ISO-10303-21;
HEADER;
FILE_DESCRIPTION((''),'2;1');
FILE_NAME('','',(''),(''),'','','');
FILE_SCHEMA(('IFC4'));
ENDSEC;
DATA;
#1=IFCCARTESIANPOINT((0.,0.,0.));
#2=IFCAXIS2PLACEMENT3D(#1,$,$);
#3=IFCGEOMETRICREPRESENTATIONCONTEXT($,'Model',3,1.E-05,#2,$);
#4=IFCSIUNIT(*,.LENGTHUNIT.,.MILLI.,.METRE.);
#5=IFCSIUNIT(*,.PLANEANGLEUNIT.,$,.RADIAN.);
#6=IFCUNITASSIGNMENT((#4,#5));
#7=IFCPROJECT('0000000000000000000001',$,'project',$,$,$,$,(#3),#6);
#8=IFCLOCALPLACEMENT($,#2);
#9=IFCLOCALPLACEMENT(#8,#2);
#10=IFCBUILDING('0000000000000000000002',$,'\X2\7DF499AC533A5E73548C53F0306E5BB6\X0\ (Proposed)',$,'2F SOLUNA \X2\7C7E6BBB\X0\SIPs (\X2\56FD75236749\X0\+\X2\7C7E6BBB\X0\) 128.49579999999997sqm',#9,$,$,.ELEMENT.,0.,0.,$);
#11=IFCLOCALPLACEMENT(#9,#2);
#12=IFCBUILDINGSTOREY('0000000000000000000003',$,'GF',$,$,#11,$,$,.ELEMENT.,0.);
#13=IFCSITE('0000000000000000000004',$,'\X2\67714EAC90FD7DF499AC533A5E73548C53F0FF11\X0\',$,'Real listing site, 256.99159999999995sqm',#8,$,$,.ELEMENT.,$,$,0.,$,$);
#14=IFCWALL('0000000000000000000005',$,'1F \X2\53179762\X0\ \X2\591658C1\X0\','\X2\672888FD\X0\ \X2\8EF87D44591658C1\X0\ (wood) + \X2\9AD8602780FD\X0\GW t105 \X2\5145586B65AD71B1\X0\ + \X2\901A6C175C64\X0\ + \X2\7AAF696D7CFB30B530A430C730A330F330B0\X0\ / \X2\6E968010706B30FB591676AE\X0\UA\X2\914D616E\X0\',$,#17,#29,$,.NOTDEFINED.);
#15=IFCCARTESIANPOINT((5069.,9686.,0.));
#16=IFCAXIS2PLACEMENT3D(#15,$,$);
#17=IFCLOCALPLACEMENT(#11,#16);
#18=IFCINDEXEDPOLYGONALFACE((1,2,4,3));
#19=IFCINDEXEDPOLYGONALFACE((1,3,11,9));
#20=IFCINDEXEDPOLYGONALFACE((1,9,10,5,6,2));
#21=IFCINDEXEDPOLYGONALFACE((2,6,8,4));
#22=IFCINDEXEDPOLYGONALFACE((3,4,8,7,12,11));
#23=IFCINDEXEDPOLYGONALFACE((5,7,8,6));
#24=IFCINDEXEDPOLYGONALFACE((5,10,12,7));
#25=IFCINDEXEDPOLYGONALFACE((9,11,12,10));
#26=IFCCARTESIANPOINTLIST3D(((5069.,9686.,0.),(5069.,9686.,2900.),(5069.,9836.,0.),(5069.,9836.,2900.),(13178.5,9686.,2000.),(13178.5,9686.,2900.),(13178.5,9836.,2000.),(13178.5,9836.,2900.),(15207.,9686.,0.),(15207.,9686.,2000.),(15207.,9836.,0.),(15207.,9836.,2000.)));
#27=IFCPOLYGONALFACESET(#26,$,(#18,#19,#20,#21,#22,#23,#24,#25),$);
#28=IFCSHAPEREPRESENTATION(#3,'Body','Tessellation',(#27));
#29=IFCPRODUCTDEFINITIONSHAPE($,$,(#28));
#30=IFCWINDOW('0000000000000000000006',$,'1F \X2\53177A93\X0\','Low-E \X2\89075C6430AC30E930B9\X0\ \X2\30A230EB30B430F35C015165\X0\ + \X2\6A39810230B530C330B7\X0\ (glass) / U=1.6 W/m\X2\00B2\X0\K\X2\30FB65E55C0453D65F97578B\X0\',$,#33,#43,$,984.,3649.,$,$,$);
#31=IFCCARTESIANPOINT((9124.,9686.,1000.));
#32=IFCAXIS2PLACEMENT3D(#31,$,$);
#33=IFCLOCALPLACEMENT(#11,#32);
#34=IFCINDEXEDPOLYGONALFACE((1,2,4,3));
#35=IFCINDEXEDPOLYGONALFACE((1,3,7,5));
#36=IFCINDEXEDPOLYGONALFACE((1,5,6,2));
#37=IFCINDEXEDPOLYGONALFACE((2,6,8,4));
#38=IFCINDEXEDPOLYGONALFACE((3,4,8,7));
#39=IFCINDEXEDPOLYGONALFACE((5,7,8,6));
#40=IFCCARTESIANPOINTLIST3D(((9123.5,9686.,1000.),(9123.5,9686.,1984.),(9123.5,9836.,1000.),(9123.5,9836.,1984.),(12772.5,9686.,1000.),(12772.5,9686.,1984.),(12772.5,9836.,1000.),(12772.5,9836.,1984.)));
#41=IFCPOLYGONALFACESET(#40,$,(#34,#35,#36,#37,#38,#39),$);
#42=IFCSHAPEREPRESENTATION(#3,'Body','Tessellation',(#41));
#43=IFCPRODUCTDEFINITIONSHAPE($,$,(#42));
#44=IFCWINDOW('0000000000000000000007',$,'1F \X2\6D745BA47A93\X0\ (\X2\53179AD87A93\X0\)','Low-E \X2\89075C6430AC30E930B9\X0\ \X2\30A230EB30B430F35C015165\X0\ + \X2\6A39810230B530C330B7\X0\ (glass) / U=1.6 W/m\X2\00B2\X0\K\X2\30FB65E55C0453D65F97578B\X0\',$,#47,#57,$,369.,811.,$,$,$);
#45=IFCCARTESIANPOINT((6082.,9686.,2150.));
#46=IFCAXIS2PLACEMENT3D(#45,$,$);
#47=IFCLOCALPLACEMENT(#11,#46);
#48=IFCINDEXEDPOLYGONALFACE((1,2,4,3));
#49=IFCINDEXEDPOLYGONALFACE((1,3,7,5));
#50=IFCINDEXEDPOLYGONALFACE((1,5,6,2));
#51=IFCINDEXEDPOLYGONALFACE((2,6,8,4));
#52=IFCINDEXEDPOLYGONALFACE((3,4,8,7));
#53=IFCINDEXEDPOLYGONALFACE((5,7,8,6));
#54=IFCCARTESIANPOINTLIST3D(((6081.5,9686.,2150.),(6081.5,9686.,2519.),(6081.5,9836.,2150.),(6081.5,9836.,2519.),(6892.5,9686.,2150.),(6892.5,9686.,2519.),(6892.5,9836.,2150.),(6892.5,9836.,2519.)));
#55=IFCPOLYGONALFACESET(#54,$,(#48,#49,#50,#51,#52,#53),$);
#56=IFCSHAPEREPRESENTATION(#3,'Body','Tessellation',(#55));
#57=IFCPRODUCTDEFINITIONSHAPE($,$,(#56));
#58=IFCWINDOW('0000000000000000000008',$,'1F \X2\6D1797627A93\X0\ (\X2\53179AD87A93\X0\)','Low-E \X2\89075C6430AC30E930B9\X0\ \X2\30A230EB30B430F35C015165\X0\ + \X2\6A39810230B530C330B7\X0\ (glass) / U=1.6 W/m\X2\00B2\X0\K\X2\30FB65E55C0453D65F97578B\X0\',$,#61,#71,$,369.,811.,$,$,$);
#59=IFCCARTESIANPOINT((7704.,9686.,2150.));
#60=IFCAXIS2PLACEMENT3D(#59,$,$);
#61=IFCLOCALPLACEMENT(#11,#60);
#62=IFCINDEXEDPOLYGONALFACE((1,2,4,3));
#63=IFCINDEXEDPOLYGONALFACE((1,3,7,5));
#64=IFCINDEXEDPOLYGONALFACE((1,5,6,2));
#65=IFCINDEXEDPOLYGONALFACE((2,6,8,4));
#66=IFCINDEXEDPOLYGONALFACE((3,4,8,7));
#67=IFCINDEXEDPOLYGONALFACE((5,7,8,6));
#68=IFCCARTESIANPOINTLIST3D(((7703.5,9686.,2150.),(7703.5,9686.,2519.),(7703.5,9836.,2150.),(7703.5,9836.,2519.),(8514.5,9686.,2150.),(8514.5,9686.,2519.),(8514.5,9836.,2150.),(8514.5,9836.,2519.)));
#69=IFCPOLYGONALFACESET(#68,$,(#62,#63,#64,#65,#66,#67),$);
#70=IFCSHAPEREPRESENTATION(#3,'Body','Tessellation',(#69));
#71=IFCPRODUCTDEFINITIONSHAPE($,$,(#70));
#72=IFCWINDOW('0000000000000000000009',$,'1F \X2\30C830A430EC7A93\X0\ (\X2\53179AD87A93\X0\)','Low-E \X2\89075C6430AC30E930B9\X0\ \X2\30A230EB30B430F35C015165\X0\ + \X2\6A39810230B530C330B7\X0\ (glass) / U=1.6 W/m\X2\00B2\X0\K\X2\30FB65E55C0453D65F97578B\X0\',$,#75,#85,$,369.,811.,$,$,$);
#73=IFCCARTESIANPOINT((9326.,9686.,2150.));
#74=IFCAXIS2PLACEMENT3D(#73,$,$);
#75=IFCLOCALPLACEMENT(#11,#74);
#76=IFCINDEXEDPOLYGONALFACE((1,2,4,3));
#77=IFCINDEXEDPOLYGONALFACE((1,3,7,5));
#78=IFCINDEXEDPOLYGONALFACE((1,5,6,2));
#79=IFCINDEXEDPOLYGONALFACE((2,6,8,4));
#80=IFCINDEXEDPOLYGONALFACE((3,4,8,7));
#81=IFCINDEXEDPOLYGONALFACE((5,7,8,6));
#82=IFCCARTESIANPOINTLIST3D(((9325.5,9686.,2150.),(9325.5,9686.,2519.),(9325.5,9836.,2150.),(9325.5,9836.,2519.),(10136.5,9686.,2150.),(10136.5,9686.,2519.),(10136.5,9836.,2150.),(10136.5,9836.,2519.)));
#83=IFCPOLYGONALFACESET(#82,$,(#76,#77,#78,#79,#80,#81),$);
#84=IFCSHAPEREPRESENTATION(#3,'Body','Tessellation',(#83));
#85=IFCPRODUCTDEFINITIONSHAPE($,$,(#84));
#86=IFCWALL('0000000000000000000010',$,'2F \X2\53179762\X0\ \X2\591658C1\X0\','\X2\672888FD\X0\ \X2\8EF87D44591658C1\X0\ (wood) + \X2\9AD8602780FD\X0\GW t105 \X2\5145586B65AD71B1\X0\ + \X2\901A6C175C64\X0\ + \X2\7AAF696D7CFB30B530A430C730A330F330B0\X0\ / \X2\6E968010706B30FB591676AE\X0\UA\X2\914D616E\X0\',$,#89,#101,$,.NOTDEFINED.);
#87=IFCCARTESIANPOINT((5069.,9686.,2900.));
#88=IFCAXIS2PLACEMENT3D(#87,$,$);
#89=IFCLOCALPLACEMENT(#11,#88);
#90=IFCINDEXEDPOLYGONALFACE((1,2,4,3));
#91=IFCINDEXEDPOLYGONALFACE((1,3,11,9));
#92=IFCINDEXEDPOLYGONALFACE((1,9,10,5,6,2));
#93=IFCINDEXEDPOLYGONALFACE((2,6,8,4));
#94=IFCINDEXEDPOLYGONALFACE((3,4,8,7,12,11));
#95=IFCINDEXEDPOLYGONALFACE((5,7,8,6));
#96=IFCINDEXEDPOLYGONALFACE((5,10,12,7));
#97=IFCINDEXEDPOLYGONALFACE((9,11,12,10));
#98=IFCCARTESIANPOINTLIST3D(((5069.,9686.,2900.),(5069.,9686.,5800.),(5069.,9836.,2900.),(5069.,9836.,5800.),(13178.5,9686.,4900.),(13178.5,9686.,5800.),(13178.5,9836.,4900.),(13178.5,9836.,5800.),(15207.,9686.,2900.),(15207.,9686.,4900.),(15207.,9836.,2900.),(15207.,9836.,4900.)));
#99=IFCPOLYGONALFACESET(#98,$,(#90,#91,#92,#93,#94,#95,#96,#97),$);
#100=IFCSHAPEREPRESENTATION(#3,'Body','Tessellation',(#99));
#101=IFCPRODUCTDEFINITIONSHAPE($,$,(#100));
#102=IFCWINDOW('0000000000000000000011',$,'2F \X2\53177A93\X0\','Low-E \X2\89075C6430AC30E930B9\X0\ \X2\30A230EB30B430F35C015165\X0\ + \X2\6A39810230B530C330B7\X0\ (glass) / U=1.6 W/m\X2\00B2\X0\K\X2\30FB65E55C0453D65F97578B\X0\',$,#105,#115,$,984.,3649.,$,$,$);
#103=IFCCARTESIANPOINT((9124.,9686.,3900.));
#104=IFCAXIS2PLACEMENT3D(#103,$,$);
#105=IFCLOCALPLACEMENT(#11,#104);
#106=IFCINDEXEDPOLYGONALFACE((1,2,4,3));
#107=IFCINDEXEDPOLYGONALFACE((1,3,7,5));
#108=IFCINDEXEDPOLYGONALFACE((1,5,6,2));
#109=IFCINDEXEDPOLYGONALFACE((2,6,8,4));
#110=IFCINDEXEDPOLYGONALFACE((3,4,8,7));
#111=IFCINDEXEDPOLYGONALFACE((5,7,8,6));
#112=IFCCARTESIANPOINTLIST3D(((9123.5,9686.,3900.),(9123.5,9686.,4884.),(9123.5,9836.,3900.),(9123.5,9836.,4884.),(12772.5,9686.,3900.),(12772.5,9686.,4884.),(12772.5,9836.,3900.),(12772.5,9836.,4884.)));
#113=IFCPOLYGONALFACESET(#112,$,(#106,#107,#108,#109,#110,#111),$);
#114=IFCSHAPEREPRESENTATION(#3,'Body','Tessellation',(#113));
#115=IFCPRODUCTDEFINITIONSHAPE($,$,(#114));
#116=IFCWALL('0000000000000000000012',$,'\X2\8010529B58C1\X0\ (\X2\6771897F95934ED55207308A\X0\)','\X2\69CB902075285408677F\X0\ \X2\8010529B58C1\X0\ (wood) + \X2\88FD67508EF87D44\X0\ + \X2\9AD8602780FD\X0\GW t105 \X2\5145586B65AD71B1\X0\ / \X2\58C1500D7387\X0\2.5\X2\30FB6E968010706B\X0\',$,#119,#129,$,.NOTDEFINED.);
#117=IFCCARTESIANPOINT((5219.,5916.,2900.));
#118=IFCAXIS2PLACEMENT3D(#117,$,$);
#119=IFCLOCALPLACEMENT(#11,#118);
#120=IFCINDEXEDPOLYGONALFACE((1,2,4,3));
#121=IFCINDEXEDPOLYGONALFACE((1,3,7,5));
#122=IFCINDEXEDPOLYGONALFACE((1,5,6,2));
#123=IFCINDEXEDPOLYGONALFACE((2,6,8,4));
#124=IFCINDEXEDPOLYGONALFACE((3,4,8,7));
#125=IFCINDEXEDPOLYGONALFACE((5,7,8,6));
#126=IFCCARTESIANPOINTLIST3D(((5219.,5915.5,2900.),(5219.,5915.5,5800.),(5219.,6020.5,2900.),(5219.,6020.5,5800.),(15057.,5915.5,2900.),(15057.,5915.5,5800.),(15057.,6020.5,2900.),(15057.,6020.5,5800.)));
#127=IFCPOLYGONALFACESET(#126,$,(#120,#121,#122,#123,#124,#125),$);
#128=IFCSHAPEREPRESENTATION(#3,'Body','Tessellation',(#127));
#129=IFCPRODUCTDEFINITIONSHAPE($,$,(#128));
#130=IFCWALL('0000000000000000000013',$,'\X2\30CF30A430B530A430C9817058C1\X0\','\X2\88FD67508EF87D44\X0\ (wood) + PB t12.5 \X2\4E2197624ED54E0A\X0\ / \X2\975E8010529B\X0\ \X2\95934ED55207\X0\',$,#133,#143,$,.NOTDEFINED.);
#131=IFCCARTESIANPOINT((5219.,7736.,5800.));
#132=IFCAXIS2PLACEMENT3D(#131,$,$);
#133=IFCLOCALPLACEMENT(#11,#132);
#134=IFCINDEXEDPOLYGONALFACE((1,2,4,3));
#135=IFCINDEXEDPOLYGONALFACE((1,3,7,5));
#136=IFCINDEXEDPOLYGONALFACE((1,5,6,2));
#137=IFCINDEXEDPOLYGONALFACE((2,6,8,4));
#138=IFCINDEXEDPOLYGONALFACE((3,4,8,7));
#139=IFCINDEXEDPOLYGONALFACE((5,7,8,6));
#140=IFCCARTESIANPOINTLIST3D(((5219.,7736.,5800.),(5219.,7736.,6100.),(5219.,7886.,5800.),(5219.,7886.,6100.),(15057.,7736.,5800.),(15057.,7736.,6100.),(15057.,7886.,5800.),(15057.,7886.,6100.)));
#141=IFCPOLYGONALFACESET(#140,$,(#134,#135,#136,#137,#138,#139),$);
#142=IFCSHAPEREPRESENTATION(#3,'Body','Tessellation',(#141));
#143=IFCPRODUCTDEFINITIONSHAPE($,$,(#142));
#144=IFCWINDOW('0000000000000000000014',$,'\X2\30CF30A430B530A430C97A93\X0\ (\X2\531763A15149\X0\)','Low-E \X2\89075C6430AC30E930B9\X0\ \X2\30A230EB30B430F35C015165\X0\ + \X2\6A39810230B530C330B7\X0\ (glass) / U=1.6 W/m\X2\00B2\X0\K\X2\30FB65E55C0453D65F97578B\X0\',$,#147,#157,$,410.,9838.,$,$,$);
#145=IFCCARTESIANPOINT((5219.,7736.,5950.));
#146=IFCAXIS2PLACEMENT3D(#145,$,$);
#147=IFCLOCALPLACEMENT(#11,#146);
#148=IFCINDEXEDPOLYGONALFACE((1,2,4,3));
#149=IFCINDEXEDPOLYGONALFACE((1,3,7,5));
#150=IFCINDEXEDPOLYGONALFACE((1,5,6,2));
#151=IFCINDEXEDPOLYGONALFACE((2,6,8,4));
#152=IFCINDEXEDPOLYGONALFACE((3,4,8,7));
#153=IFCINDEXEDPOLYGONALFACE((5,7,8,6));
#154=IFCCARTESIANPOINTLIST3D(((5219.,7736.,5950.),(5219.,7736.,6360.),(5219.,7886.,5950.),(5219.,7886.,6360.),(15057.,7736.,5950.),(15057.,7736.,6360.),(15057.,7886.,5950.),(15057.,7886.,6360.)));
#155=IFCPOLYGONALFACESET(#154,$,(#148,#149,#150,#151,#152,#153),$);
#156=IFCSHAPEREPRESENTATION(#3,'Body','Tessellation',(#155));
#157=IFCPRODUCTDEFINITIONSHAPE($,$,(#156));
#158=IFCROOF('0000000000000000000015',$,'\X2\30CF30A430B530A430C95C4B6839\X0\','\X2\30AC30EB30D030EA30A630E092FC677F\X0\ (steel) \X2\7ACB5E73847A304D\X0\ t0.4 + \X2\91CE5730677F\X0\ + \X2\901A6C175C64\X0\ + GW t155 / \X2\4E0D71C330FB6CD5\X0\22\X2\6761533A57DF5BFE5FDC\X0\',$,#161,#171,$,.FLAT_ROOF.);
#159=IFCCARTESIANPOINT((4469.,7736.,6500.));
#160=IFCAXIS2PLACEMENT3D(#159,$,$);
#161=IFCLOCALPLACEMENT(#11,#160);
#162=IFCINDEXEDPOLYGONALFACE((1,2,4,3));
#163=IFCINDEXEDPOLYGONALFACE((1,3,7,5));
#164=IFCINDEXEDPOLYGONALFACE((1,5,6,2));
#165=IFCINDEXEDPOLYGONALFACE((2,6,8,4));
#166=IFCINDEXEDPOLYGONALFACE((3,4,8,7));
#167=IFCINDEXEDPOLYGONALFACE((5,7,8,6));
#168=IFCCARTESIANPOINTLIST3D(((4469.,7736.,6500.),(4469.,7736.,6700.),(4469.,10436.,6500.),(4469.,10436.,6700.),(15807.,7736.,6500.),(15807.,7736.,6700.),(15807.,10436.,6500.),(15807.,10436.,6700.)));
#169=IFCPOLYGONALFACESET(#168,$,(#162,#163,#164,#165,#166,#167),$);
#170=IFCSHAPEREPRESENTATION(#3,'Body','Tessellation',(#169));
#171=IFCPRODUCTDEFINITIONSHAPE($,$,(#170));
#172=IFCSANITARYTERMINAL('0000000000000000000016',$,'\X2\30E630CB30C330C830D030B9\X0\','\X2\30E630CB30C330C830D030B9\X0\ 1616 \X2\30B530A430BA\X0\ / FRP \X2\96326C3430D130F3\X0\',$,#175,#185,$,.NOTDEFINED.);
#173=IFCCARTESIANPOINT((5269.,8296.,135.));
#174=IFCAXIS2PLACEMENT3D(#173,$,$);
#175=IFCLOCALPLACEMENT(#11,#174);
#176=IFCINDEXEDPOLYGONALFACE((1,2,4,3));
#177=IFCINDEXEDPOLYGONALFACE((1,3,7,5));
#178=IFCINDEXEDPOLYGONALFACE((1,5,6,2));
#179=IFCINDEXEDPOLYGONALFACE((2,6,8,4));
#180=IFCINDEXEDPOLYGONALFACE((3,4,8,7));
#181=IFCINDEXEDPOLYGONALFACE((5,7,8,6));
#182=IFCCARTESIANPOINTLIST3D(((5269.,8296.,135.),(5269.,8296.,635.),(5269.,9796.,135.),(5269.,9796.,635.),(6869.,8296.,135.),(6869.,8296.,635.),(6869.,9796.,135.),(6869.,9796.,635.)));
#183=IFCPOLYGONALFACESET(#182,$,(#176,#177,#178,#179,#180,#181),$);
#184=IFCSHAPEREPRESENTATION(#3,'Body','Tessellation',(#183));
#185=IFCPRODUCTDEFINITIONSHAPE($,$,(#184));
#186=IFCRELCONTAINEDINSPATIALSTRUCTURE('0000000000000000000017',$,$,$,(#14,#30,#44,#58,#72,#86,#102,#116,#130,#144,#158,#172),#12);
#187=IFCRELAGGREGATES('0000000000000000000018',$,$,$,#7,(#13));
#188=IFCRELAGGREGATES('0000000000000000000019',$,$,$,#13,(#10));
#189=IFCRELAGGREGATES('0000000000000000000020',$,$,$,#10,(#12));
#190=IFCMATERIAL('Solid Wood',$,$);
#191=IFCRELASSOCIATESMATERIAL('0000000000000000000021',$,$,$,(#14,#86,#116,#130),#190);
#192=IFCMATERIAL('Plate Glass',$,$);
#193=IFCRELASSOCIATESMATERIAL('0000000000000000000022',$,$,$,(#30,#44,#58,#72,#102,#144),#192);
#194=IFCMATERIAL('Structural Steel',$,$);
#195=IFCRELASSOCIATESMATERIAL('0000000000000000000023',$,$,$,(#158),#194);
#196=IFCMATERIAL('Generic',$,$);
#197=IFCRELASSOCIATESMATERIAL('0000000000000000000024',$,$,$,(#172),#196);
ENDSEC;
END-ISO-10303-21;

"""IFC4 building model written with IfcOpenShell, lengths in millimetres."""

from ifc_helpers import new_model, si_unit, frame, frame_2d, origin, place, context, project, spatial, rectangle, extrude, material, element, fill, save


model = new_model("IFC4")

# Units and contexts
model_context = context("Model", 3, precision=1e-05, world=origin())
ifc_project = project(units=[si_unit("LENGTHUNIT", "METRE", prefix="MILLI"), si_unit("PLANEANGLEUNIT", "RADIAN")], contexts=[model_context])

# Site, building, storey
site_placement = place(None, origin())
site = spatial("IfcSite", under=ifc_project, at=site_placement, Name="東京都練馬区平和台１", ObjectType="Real listing site, 256.99159999999995sqm", CompositionType="ELEMENT", RefElevation=0.0)
building_placement = place(site_placement, origin())
building = spatial("IfcBuilding", under=site, at=building_placement, Name="練馬区平和台の家 (Proposed)", ObjectType="2F SOLUNA 籾殻SIPs (国産杉+籾殻) 128.49579999999997sqm", CompositionType="ELEMENT", ElevationOfRefHeight=0.0, ElevationOfTerrain=0.0)
storey_placement = place(building_placement, origin())
storey = spatial("IfcBuildingStorey", under=building, at=storey_placement, Name="GF", CompositionType="ELEMENT", Elevation=0.0)

# Wall, openings, windows
ifc_material_1 = material(Name="Solid Wood")
wall_1_placement = place(storey_placement, frame((5069.0, 9686.0, 0.0)))
wall_1 = element("IfcWall", 1, at=wall_1_placement, inside=storey, material=ifc_material_1, Name="1F 北面 外壁", Description="木製 軸組外壁 (wood) + 高性能GW t105 充填断熱 + 通気層 + 窯業系サイディング / 準耐火・外皮UA配慮", PredefinedType="NOTDEFINED", context=model_context, shape_type="SweptSolid", body=[
    extrude(rectangle(XDim=10138.0, YDim=150.0, at=frame_2d((5069.0, 75.0))), frame((5069.0, 9686.0, 0.0)), (0.0, 0.0, 1.0), 2900.0),
])
opening_1_placement = place(storey_placement, frame((9124.0, 9686.0, 1000.0)))
opening_1 = element("IfcOpeningElement", 2, at=opening_1_placement, cuts=wall_1, PredefinedType="NOTDEFINED", context=model_context, shape_type="SweptSolid", body=[
    extrude(rectangle(XDim=3649.0, YDim=150.0, at=frame_2d((1824.0, 75.0))), frame((9124.0, 9686.0, 1000.0)), (0.0, 0.0, 1.0), 984.0),
])
opening_2_placement = place(storey_placement, frame((6082.0, 9686.0, 2150.0)))
opening_2 = element("IfcOpeningElement", 3, at=opening_2_placement, cuts=wall_1, PredefinedType="NOTDEFINED", context=model_context, shape_type="SweptSolid", body=[
    extrude(rectangle(XDim=811.0, YDim=150.0, at=frame_2d((405.0, 75.0))), frame((6082.0, 9686.0, 2150.0)), (0.0, 0.0, 1.0), 369.0),
])
opening_3_placement = place(storey_placement, frame((7704.0, 9686.0, 2150.0)))
opening_3 = element("IfcOpeningElement", 4, at=opening_3_placement, cuts=wall_1, PredefinedType="NOTDEFINED", context=model_context, shape_type="SweptSolid", body=[
    extrude(rectangle(XDim=811.0, YDim=150.0, at=frame_2d((405.0, 75.0))), frame((7704.0, 9686.0, 2150.0)), (0.0, 0.0, 1.0), 369.0),
])
opening_4_placement = place(storey_placement, frame((9326.0, 9686.0, 2150.0)))
opening_4 = element("IfcOpeningElement", 5, at=opening_4_placement, cuts=wall_1, PredefinedType="NOTDEFINED", context=model_context, shape_type="SweptSolid", body=[
    extrude(rectangle(XDim=811.0, YDim=150.0, at=frame_2d((405.0, 75.0))), frame((9326.0, 9686.0, 2150.0)), (0.0, 0.0, 1.0), 369.0),
])
ifc_material_2 = material(Name="Plate Glass")
window_1_placement = place(storey_placement, frame((9124.0, 9686.0, 1000.0)))
window_1 = element("IfcWindow", 6, at=window_1_placement, inside=storey, material=ifc_material_2, Name="1F 北窓", Description="Low-E 複層ガラス アルゴン封入 + 樹脂サッシ (glass) / U=1.6 W/m²K・日射取得型", OverallHeight=984.0, OverallWidth=3649.0, context=model_context, shape_type="SweptSolid", body=[
    extrude(rectangle(XDim=3649.0, YDim=150.0, at=frame_2d((1824.0, 75.0))), frame((9124.0, 9686.0, 1000.0)), (0.0, 0.0, 1.0), 984.0),
])
fill(opening_1, window_1)
window_2_placement = place(storey_placement, frame((6082.0, 9686.0, 2150.0)))
window_2 = element("IfcWindow", 7, at=window_2_placement, inside=storey, material=ifc_material_2, Name="1F 浴室窓 (北高窓)", Description="Low-E 複層ガラス アルゴン封入 + 樹脂サッシ (glass) / U=1.6 W/m²K・日射取得型", OverallHeight=369.0, OverallWidth=811.0, context=model_context, shape_type="SweptSolid", body=[
    extrude(rectangle(XDim=811.0, YDim=150.0, at=frame_2d((405.0, 75.0))), frame((6082.0, 9686.0, 2150.0)), (0.0, 0.0, 1.0), 369.0),
])
fill(opening_2, window_2)
window_3_placement = place(storey_placement, frame((7704.0, 9686.0, 2150.0)))
window_3 = element("IfcWindow", 8, at=window_3_placement, inside=storey, material=ifc_material_2, Name="1F 洗面窓 (北高窓)", Description="Low-E 複層ガラス アルゴン封入 + 樹脂サッシ (glass) / U=1.6 W/m²K・日射取得型", OverallHeight=369.0, OverallWidth=811.0, context=model_context, shape_type="SweptSolid", body=[
    extrude(rectangle(XDim=811.0, YDim=150.0, at=frame_2d((405.0, 75.0))), frame((7704.0, 9686.0, 2150.0)), (0.0, 0.0, 1.0), 369.0),
])
fill(opening_3, window_3)
window_4_placement = place(storey_placement, frame((9326.0, 9686.0, 2150.0)))
window_4 = element("IfcWindow", 9, at=window_4_placement, inside=storey, material=ifc_material_2, Name="1F トイレ窓 (北高窓)", Description="Low-E 複層ガラス アルゴン封入 + 樹脂サッシ (glass) / U=1.6 W/m²K・日射取得型", OverallHeight=369.0, OverallWidth=811.0, context=model_context, shape_type="SweptSolid", body=[
    extrude(rectangle(XDim=811.0, YDim=150.0, at=frame_2d((405.0, 75.0))), frame((9326.0, 9686.0, 2150.0)), (0.0, 0.0, 1.0), 369.0),
])
fill(opening_4, window_4)

# Wall, opening, window
wall_2_placement = place(storey_placement, frame((5069.0, 9686.0, 2900.0)))
wall_2 = element("IfcWall", 10, at=wall_2_placement, inside=storey, material=ifc_material_1, Name="2F 北面 外壁", Description="木製 軸組外壁 (wood) + 高性能GW t105 充填断熱 + 通気層 + 窯業系サイディング / 準耐火・外皮UA配慮", PredefinedType="NOTDEFINED", context=model_context, shape_type="SweptSolid", body=[
    extrude(rectangle(XDim=10138.0, YDim=150.0, at=frame_2d((5069.0, 75.0))), frame((5069.0, 9686.0, 2900.0)), (0.0, 0.0, 1.0), 2900.0),
])
opening_5_placement = place(storey_placement, frame((9124.0, 9686.0, 3900.0)))
opening_5 = element("IfcOpeningElement", 11, at=opening_5_placement, cuts=wall_2, PredefinedType="NOTDEFINED", context=model_context, shape_type="SweptSolid", body=[
    extrude(rectangle(XDim=3649.0, YDim=150.0, at=frame_2d((1824.0, 75.0))), frame((9124.0, 9686.0, 3900.0)), (0.0, 0.0, 1.0), 984.0),
])
window_5_placement = place(storey_placement, frame((9124.0, 9686.0, 3900.0)))
window_5 = element("IfcWindow", 12, at=window_5_placement, inside=storey, material=ifc_material_2, Name="2F 北窓", Description="Low-E 複層ガラス アルゴン封入 + 樹脂サッシ (glass) / U=1.6 W/m²K・日射取得型", OverallHeight=984.0, OverallWidth=3649.0, context=model_context, shape_type="SweptSolid", body=[
    extrude(rectangle(XDim=3649.0, YDim=150.0, at=frame_2d((1824.0, 75.0))), frame((9124.0, 9686.0, 3900.0)), (0.0, 0.0, 1.0), 984.0),
])
fill(opening_5, window_5)

# Wall
wall_3_placement = place(storey_placement, frame((5219.0, 5916.0, 2900.0)))
element("IfcWall", 13, at=wall_3_placement, inside=storey, material=ifc_material_1, Name="耐力壁 (東西間仕切り)", Description="構造用合板 耐力壁 (wood) + 製材軸組 + 高性能GW t105 充填断熱 / 壁倍率2.5・準耐火", PredefinedType="NOTDEFINED", context=model_context, shape_type="SweptSolid", body=[
    extrude(rectangle(XDim=9838.0, YDim=105.0, at=frame_2d((4919.0, 52.0))), frame((5219.0, 5916.0, 2900.0)), (0.0, 0.0, 1.0), 2900.0),
])

# Wall, opening, window
wall_4_placement = place(storey_placement, frame((5219.0, 7736.0, 5800.0)))
wall_4 = element("IfcWall", 14, at=wall_4_placement, inside=storey, material=ifc_material_1, Name="ハイサイド腰壁", Description="製材軸組 (wood) + PB t12.5 両面仕上 / 非耐力 間仕切", PredefinedType="NOTDEFINED", context=model_context, shape_type="SweptSolid", body=[
    extrude(rectangle(XDim=9838.0, YDim=150.0, at=frame_2d((4919.0, 75.0))), frame((5219.0, 7736.0, 5800.0)), (0.0, 0.0, 1.0), 700.0),
])
opening_6_placement = place(storey_placement, frame((5219.0, 7736.0, 5950.0)))
opening_6 = element("IfcOpeningElement", 15, at=opening_6_placement, cuts=wall_4, PredefinedType="NOTDEFINED", context=model_context, shape_type="SweptSolid", body=[
    extrude(rectangle(XDim=9838.0, YDim=150.0, at=frame_2d((4919.0, 75.0))), frame((5219.0, 7736.0, 5950.0)), (0.0, 0.0, 1.0), 410.0),
])
window_6_placement = place(storey_placement, frame((5219.0, 7736.0, 5950.0)))
window_6 = element("IfcWindow", 16, at=window_6_placement, inside=storey, material=ifc_material_2, Name="ハイサイド窓 (北採光)", Description="Low-E 複層ガラス アルゴン封入 + 樹脂サッシ (glass) / U=1.6 W/m²K・日射取得型", OverallHeight=410.0, OverallWidth=9838.0, context=model_context, shape_type="SweptSolid", body=[
    extrude(rectangle(XDim=9838.0, YDim=150.0, at=frame_2d((4919.0, 75.0))), frame((5219.0, 7736.0, 5950.0)), (0.0, 0.0, 1.0), 410.0),
])
fill(opening_6, window_6)

# Roof
ifc_material_3 = material(Name="Structural Steel")
roof_placement = place(storey_placement, frame((4469.0, 7736.0, 6500.0)))
element("IfcRoof", 17, at=roof_placement, inside=storey, material=ifc_material_3, Name="ハイサイド屋根", Description="ガルバリウム鋼板 (steel) 立平葺き t0.4 + 野地板 + 通気層 + GW t155 / 不燃・法22条区域対応", PredefinedType="FLAT_ROOF", context=model_context, shape_type="SweptSolid", body=[
    extrude(rectangle(XDim=11338.0, YDim=2700.0, at=frame_2d((5669.0, 1350.0))), frame((4469.0, 7736.0, 6500.0)), (0.0, 0.0, 1.0), 200.0),
])

# Sanitary terminal
ifc_material_4 = material(Name="Generic")
sanitary_terminal_placement = place(storey_placement, frame((5269.0, 8296.0, 135.0)))
element("IfcSanitaryTerminal", 18, at=sanitary_terminal_placement, inside=storey, material=ifc_material_4, Name="ユニットバス", Description="ユニットバス 1616 サイズ / FRP 防水パン", PredefinedType="NOTDEFINED", context=model_context, shape_type="SweptSolid", body=[
    extrude(rectangle(XDim=1600.0, YDim=1500.0, at=frame_2d((800.0, 750.0))), frame((5269.0, 8296.0, 135.0)), (0.0, 0.0, 1.0), 500.0),
])

save(model, "model.ifc")
